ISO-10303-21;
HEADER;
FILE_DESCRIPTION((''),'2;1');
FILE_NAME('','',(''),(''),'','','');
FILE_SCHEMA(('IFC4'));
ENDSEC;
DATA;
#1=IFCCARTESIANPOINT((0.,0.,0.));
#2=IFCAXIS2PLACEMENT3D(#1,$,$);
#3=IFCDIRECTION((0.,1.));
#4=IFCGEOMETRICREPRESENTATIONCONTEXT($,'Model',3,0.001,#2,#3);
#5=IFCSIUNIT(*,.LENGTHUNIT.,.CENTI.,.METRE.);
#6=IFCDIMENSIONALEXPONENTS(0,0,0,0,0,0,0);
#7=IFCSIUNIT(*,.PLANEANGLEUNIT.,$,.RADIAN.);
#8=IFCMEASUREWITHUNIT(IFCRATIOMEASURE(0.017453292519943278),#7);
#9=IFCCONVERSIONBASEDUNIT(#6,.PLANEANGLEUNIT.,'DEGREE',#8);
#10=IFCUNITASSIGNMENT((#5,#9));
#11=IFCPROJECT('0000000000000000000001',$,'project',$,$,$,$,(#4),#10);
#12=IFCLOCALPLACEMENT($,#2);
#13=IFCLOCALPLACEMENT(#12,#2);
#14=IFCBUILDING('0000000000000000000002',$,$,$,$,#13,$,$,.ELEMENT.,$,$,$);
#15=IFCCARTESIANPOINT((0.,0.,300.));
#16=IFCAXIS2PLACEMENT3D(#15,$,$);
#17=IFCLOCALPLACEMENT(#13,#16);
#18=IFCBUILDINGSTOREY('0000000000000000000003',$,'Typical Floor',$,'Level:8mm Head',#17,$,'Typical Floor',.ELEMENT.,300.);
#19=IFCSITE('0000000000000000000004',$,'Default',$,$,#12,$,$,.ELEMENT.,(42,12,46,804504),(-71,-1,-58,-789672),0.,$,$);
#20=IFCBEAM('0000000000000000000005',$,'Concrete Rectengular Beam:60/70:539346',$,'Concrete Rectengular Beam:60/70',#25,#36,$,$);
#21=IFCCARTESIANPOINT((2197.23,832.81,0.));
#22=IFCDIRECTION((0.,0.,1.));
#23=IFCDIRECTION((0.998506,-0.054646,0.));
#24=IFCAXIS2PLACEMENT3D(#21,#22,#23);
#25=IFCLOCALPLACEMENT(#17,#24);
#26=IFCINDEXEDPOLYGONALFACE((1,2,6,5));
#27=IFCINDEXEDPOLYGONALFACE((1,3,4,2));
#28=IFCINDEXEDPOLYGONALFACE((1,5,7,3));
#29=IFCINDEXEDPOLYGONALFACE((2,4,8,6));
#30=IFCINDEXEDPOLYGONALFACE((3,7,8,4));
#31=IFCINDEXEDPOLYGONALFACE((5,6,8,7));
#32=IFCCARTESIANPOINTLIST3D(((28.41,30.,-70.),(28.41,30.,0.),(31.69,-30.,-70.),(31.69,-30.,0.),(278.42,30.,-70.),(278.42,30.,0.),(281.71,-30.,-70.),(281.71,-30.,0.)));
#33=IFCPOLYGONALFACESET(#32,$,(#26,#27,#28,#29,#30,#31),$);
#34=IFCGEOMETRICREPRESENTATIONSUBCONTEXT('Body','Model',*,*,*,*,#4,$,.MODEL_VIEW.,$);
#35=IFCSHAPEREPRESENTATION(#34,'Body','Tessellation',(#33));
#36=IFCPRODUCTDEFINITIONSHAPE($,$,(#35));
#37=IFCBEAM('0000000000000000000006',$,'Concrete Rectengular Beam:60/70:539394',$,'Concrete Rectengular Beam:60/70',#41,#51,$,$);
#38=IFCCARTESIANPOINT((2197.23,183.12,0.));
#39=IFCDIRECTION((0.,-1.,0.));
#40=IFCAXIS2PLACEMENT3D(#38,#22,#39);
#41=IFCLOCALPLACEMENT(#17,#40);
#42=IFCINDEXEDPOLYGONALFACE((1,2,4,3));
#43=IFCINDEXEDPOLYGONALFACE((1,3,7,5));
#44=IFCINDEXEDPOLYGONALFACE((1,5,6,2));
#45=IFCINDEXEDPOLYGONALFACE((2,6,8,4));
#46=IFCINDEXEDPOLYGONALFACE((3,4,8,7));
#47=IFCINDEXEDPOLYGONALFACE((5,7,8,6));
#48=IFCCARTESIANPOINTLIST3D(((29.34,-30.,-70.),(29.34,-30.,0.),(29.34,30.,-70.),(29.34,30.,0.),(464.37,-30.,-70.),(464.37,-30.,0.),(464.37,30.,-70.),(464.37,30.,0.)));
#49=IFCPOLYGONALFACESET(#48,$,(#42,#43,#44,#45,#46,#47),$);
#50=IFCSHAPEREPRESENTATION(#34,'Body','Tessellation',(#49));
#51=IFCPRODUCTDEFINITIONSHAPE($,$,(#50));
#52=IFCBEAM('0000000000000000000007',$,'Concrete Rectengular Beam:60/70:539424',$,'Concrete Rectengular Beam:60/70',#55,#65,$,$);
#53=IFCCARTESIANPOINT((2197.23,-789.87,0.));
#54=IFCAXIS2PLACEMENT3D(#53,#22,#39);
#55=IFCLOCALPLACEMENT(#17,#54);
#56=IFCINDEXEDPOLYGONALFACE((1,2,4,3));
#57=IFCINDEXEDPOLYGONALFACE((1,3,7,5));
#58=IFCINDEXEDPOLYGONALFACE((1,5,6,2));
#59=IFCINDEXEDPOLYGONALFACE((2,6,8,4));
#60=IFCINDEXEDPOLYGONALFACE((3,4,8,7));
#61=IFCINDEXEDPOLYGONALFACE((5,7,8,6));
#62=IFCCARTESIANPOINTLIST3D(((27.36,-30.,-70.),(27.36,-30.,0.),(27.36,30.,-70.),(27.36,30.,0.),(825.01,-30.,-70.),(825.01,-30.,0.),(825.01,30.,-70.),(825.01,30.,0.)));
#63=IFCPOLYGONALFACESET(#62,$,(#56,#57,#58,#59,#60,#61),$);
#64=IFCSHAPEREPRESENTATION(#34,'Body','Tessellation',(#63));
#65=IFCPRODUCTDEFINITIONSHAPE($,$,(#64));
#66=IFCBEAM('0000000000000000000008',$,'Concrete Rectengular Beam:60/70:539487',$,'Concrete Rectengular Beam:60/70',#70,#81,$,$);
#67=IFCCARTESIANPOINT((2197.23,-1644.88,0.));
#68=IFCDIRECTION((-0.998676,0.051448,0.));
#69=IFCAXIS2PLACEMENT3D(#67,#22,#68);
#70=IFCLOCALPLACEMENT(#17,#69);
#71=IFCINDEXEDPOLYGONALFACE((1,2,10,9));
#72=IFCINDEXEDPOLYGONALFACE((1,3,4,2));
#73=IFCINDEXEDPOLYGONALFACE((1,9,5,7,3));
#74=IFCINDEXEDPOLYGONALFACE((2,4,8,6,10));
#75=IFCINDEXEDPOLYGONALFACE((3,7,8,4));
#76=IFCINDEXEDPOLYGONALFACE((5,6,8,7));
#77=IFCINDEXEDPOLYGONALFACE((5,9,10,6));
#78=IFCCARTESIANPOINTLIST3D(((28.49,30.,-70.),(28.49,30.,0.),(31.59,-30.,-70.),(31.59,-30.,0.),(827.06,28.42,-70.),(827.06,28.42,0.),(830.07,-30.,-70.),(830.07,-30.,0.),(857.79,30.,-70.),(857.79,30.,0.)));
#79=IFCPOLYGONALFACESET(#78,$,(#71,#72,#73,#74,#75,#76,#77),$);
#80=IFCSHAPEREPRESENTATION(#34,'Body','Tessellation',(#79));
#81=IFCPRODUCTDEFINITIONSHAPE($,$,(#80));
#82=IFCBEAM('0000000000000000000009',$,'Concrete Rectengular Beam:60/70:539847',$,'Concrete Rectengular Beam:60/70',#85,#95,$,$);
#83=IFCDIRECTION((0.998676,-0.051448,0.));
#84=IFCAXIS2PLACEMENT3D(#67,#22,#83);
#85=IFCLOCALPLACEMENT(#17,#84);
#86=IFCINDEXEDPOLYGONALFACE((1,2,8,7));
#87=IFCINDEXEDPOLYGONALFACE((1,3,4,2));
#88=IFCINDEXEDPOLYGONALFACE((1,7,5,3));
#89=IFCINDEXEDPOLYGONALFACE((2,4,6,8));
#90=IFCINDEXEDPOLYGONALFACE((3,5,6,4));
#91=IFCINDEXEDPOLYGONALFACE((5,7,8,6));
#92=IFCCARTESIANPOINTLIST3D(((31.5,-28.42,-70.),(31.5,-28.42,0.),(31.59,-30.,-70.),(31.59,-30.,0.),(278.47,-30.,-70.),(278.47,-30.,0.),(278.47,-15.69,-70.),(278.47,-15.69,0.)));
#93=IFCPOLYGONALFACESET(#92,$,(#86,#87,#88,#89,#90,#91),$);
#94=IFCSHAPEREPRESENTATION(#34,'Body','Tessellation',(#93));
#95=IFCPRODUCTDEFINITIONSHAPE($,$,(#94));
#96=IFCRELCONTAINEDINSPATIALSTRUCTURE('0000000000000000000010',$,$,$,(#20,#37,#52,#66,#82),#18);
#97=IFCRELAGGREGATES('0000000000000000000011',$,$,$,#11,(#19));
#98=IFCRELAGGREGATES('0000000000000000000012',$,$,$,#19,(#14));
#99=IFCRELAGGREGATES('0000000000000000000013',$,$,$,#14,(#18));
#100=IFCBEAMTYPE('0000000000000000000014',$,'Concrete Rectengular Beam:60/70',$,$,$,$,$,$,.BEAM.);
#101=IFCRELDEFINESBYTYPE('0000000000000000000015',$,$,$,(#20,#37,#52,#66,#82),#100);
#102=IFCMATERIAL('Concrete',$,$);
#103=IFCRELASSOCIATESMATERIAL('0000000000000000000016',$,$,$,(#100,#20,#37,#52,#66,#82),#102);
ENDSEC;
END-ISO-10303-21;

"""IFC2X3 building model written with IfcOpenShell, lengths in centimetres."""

from ifc_helpers import new_model, entity, si_unit, converted_unit, direction, frame, frame_2d, origin, origin_2d_with_axis, place, context, subcontext, project, spatial, polyline, rectangle, extrude, clip, halfspace, bounded_halfspace, material, type_object, element, save


model = new_model("IFC2X3")

# Units and contexts
model_context = context("Model", 3, precision=0.001, world=origin(), true_north=direction((0.0, 1.0)))
body_context = subcontext(model_context, "Body", "Model", "MODEL_VIEW")
ifc_project = project(units=[si_unit("LENGTHUNIT", "METRE", prefix="CENTI"), converted_unit("PLANEANGLEUNIT", "DEGREE", entity("IfcRatioMeasure", 0.017453292519943278), si_unit("PLANEANGLEUNIT", "RADIAN"), dimensions=[0, 0, 0, 0, 0, 0, 0])], contexts=[model_context])

# Site, building, storey
site_placement = place(None, origin())
site = spatial("IfcSite", under=ifc_project, at=site_placement, Name="Default", CompositionType="ELEMENT", RefLatitude=(42, 12, 46, 804504), RefLongitude=(-71, -1, -58, -789672), RefElevation=0.0)
building_placement = place(site_placement, origin())
building = spatial("IfcBuilding", under=site, at=building_placement, CompositionType="ELEMENT")
storey_placement = place(building_placement, frame((0.0, 0.0, 300.0)))
storey = spatial("IfcBuildingStorey", under=building, at=storey_placement, Name="Typical Floor", ObjectType="Level:8mm Head", LongName="Typical Floor", CompositionType="ELEMENT", Elevation=300.0)

# Beams
ifc_material = material(Name="Concrete")
beam_type = type_object("IfcBeamType", Name="Concrete Rectengular Beam:60/70", PredefinedType="BEAM", material=ifc_material)
beam_1_placement = place(storey_placement, frame((2197.23, 832.81, 0.0), z_axis=(0.0, 0.0, 1.0), x_axis=(0.998506, -0.054646, 0.0)))
element("IfcBeam", 1, at=beam_1_placement, inside=storey, type_object=beam_type, material=ifc_material, Name="Concrete Rectengular Beam:60/70:539346", ObjectType="Concrete Rectengular Beam:60/70", context=body_context, shape_type="SweptSolid", body=[
    clip(clip(extrude(rectangle(XDim=70.0, YDim=60.0, at=frame_2d((0.0, 0.0), x_axis=(1.0, 0.0))), frame((28.41, 0.0, -35.0), z_axis=(1.0, 0.0, 0.0), x_axis=(0.0, 0.0, -1.0)), (0.0, 0.0, 1.0), 253.3), halfspace(frame((28.18, 34.13, 0.0), z_axis=(-0.998506, -0.054646, 0.0), x_axis=(0.054646, -0.998506, 0.0)), False)), halfspace(frame((281.84, -32.4, -70.0), z_axis=(0.998506, 0.054646, 0.0), x_axis=(-0.054646, 0.998506, 0.0)), False)),
])
beam_2_placement = place(storey_placement, frame((2197.23, 183.12, 0.0), z_axis=(0.0, 0.0, 1.0), x_axis=(0.0, -1.0, 0.0)))
element("IfcBeam", 2, at=beam_2_placement, inside=storey, type_object=beam_type, material=ifc_material, Name="Concrete Rectengular Beam:60/70:539394", ObjectType="Concrete Rectengular Beam:60/70", context=body_context, shape_type="SweptSolid", body=[
    extrude(rectangle(XDim=70.0, YDim=60.0, at=origin_2d_with_axis()), frame((29.34, 0.0, -35.0), z_axis=(1.0, 0.0, 0.0), x_axis=(0.0, 0.0, -1.0)), (0.0, 0.0, 1.0), 435.03),
])
beam_3_placement = place(storey_placement, frame((2197.23, -789.87, 0.0), z_axis=(0.0, 0.0, 1.0), x_axis=(0.0, -1.0, 0.0)))
element("IfcBeam", 3, at=beam_3_placement, inside=storey, type_object=beam_type, material=ifc_material, Name="Concrete Rectengular Beam:60/70:539424", ObjectType="Concrete Rectengular Beam:60/70", context=body_context, shape_type="SweptSolid", body=[
    extrude(rectangle(XDim=70.0, YDim=60.0, at=frame_2d((0.0, 0.0), x_axis=(1.0, 0.0))), frame((27.36, 0.0, -35.0), z_axis=(1.0, 0.0, 0.0), x_axis=(0.0, 0.0, -1.0)), (0.0, 0.0, 1.0), 797.65),
])
beam_4_placement = place(storey_placement, frame((2197.23, -1644.88, 0.0), z_axis=(0.0, 0.0, 1.0), x_axis=(-0.998676, 0.051448, 0.0)))
element("IfcBeam", 4, at=beam_4_placement, inside=storey, type_object=beam_type, material=ifc_material, Name="Concrete Rectengular Beam:60/70:539487", ObjectType="Concrete Rectengular Beam:60/70", context=body_context, shape_type="SweptSolid", body=[
    clip(clip(clip(extrude(rectangle(XDim=70.0, YDim=60.0, at=frame_2d((0.0, 0.0), x_axis=(1.0, 0.0))), frame((28.49, 0.0, -35.0), z_axis=(1.0, 0.0, 0.0), x_axis=(0.0, 0.0, -1.0)), (0.0, 0.0, 1.0), 829.3), halfspace(frame((31.57, -29.69, 0.0), z_axis=(-0.998676, -0.051448, 0.0), x_axis=(0.051448, -0.998676, 0.0)), False)), bounded_halfspace(frame((827.06, 28.42, 0.0), z_axis=(0.998676, 0.051448, 0.0), x_axis=(0.0, 0.0, -1.0)), False, frame((28.49, 0.0, -35.0), z_axis=(1.0, 0.0, 0.0), x_axis=(0.0, 0.0, -1.0)), polyline([(35.0, 28.42), (-35.0, 28.42), (-35.0, -30.0), (35.0, -30.0), (35.0, 28.42)]))), bounded_halfspace(frame((886.98, 31.5, 0.0), z_axis=(0.051448, -0.998676, 0.0), x_axis=(0.0, 0.0, -1.0)), False, frame((28.49, 0.0, -35.0), z_axis=(1.0, 0.0, 0.0), x_axis=(0.0, 0.0, -1.0)), polyline([(-35.0, 28.42), (35.0, 28.42), (35.0, 30.0), (-35.0, 30.0), (-35.0, 28.42)]))),
])
beam_5_placement = place(storey_placement, frame((2197.23, -1644.88, 0.0), z_axis=(0.0, 0.0, 1.0), x_axis=(0.998676, -0.051448, 0.0)))
element("IfcBeam", 5, at=beam_5_placement, inside=storey, type_object=beam_type, material=ifc_material, Name="Concrete Rectengular Beam:60/70:539847", ObjectType="Concrete Rectengular Beam:60/70", context=body_context, shape_type="SweptSolid", body=[
    clip(clip(extrude(rectangle(XDim=70.0, YDim=60.0, at=origin_2d_with_axis()), frame((0.77, 0.0, -35.0), z_axis=(1.0, 0.0, 0.0), x_axis=(0.0, 0.0, -1.0)), (0.0, 0.0, 1.0), 277.7), halfspace(frame((28.35, 32.77, -70.0), z_axis=(-0.998676, -0.051448, 0.0), x_axis=(-0.051448, 0.998676, 0.0)), False)), halfspace(frame((-28.42, -31.5, 0.0), z_axis=(-0.051448, 0.998676, 0.0), x_axis=(0.0, 0.0, -1.0)), False)),
])

save(model, "model.ifc")
